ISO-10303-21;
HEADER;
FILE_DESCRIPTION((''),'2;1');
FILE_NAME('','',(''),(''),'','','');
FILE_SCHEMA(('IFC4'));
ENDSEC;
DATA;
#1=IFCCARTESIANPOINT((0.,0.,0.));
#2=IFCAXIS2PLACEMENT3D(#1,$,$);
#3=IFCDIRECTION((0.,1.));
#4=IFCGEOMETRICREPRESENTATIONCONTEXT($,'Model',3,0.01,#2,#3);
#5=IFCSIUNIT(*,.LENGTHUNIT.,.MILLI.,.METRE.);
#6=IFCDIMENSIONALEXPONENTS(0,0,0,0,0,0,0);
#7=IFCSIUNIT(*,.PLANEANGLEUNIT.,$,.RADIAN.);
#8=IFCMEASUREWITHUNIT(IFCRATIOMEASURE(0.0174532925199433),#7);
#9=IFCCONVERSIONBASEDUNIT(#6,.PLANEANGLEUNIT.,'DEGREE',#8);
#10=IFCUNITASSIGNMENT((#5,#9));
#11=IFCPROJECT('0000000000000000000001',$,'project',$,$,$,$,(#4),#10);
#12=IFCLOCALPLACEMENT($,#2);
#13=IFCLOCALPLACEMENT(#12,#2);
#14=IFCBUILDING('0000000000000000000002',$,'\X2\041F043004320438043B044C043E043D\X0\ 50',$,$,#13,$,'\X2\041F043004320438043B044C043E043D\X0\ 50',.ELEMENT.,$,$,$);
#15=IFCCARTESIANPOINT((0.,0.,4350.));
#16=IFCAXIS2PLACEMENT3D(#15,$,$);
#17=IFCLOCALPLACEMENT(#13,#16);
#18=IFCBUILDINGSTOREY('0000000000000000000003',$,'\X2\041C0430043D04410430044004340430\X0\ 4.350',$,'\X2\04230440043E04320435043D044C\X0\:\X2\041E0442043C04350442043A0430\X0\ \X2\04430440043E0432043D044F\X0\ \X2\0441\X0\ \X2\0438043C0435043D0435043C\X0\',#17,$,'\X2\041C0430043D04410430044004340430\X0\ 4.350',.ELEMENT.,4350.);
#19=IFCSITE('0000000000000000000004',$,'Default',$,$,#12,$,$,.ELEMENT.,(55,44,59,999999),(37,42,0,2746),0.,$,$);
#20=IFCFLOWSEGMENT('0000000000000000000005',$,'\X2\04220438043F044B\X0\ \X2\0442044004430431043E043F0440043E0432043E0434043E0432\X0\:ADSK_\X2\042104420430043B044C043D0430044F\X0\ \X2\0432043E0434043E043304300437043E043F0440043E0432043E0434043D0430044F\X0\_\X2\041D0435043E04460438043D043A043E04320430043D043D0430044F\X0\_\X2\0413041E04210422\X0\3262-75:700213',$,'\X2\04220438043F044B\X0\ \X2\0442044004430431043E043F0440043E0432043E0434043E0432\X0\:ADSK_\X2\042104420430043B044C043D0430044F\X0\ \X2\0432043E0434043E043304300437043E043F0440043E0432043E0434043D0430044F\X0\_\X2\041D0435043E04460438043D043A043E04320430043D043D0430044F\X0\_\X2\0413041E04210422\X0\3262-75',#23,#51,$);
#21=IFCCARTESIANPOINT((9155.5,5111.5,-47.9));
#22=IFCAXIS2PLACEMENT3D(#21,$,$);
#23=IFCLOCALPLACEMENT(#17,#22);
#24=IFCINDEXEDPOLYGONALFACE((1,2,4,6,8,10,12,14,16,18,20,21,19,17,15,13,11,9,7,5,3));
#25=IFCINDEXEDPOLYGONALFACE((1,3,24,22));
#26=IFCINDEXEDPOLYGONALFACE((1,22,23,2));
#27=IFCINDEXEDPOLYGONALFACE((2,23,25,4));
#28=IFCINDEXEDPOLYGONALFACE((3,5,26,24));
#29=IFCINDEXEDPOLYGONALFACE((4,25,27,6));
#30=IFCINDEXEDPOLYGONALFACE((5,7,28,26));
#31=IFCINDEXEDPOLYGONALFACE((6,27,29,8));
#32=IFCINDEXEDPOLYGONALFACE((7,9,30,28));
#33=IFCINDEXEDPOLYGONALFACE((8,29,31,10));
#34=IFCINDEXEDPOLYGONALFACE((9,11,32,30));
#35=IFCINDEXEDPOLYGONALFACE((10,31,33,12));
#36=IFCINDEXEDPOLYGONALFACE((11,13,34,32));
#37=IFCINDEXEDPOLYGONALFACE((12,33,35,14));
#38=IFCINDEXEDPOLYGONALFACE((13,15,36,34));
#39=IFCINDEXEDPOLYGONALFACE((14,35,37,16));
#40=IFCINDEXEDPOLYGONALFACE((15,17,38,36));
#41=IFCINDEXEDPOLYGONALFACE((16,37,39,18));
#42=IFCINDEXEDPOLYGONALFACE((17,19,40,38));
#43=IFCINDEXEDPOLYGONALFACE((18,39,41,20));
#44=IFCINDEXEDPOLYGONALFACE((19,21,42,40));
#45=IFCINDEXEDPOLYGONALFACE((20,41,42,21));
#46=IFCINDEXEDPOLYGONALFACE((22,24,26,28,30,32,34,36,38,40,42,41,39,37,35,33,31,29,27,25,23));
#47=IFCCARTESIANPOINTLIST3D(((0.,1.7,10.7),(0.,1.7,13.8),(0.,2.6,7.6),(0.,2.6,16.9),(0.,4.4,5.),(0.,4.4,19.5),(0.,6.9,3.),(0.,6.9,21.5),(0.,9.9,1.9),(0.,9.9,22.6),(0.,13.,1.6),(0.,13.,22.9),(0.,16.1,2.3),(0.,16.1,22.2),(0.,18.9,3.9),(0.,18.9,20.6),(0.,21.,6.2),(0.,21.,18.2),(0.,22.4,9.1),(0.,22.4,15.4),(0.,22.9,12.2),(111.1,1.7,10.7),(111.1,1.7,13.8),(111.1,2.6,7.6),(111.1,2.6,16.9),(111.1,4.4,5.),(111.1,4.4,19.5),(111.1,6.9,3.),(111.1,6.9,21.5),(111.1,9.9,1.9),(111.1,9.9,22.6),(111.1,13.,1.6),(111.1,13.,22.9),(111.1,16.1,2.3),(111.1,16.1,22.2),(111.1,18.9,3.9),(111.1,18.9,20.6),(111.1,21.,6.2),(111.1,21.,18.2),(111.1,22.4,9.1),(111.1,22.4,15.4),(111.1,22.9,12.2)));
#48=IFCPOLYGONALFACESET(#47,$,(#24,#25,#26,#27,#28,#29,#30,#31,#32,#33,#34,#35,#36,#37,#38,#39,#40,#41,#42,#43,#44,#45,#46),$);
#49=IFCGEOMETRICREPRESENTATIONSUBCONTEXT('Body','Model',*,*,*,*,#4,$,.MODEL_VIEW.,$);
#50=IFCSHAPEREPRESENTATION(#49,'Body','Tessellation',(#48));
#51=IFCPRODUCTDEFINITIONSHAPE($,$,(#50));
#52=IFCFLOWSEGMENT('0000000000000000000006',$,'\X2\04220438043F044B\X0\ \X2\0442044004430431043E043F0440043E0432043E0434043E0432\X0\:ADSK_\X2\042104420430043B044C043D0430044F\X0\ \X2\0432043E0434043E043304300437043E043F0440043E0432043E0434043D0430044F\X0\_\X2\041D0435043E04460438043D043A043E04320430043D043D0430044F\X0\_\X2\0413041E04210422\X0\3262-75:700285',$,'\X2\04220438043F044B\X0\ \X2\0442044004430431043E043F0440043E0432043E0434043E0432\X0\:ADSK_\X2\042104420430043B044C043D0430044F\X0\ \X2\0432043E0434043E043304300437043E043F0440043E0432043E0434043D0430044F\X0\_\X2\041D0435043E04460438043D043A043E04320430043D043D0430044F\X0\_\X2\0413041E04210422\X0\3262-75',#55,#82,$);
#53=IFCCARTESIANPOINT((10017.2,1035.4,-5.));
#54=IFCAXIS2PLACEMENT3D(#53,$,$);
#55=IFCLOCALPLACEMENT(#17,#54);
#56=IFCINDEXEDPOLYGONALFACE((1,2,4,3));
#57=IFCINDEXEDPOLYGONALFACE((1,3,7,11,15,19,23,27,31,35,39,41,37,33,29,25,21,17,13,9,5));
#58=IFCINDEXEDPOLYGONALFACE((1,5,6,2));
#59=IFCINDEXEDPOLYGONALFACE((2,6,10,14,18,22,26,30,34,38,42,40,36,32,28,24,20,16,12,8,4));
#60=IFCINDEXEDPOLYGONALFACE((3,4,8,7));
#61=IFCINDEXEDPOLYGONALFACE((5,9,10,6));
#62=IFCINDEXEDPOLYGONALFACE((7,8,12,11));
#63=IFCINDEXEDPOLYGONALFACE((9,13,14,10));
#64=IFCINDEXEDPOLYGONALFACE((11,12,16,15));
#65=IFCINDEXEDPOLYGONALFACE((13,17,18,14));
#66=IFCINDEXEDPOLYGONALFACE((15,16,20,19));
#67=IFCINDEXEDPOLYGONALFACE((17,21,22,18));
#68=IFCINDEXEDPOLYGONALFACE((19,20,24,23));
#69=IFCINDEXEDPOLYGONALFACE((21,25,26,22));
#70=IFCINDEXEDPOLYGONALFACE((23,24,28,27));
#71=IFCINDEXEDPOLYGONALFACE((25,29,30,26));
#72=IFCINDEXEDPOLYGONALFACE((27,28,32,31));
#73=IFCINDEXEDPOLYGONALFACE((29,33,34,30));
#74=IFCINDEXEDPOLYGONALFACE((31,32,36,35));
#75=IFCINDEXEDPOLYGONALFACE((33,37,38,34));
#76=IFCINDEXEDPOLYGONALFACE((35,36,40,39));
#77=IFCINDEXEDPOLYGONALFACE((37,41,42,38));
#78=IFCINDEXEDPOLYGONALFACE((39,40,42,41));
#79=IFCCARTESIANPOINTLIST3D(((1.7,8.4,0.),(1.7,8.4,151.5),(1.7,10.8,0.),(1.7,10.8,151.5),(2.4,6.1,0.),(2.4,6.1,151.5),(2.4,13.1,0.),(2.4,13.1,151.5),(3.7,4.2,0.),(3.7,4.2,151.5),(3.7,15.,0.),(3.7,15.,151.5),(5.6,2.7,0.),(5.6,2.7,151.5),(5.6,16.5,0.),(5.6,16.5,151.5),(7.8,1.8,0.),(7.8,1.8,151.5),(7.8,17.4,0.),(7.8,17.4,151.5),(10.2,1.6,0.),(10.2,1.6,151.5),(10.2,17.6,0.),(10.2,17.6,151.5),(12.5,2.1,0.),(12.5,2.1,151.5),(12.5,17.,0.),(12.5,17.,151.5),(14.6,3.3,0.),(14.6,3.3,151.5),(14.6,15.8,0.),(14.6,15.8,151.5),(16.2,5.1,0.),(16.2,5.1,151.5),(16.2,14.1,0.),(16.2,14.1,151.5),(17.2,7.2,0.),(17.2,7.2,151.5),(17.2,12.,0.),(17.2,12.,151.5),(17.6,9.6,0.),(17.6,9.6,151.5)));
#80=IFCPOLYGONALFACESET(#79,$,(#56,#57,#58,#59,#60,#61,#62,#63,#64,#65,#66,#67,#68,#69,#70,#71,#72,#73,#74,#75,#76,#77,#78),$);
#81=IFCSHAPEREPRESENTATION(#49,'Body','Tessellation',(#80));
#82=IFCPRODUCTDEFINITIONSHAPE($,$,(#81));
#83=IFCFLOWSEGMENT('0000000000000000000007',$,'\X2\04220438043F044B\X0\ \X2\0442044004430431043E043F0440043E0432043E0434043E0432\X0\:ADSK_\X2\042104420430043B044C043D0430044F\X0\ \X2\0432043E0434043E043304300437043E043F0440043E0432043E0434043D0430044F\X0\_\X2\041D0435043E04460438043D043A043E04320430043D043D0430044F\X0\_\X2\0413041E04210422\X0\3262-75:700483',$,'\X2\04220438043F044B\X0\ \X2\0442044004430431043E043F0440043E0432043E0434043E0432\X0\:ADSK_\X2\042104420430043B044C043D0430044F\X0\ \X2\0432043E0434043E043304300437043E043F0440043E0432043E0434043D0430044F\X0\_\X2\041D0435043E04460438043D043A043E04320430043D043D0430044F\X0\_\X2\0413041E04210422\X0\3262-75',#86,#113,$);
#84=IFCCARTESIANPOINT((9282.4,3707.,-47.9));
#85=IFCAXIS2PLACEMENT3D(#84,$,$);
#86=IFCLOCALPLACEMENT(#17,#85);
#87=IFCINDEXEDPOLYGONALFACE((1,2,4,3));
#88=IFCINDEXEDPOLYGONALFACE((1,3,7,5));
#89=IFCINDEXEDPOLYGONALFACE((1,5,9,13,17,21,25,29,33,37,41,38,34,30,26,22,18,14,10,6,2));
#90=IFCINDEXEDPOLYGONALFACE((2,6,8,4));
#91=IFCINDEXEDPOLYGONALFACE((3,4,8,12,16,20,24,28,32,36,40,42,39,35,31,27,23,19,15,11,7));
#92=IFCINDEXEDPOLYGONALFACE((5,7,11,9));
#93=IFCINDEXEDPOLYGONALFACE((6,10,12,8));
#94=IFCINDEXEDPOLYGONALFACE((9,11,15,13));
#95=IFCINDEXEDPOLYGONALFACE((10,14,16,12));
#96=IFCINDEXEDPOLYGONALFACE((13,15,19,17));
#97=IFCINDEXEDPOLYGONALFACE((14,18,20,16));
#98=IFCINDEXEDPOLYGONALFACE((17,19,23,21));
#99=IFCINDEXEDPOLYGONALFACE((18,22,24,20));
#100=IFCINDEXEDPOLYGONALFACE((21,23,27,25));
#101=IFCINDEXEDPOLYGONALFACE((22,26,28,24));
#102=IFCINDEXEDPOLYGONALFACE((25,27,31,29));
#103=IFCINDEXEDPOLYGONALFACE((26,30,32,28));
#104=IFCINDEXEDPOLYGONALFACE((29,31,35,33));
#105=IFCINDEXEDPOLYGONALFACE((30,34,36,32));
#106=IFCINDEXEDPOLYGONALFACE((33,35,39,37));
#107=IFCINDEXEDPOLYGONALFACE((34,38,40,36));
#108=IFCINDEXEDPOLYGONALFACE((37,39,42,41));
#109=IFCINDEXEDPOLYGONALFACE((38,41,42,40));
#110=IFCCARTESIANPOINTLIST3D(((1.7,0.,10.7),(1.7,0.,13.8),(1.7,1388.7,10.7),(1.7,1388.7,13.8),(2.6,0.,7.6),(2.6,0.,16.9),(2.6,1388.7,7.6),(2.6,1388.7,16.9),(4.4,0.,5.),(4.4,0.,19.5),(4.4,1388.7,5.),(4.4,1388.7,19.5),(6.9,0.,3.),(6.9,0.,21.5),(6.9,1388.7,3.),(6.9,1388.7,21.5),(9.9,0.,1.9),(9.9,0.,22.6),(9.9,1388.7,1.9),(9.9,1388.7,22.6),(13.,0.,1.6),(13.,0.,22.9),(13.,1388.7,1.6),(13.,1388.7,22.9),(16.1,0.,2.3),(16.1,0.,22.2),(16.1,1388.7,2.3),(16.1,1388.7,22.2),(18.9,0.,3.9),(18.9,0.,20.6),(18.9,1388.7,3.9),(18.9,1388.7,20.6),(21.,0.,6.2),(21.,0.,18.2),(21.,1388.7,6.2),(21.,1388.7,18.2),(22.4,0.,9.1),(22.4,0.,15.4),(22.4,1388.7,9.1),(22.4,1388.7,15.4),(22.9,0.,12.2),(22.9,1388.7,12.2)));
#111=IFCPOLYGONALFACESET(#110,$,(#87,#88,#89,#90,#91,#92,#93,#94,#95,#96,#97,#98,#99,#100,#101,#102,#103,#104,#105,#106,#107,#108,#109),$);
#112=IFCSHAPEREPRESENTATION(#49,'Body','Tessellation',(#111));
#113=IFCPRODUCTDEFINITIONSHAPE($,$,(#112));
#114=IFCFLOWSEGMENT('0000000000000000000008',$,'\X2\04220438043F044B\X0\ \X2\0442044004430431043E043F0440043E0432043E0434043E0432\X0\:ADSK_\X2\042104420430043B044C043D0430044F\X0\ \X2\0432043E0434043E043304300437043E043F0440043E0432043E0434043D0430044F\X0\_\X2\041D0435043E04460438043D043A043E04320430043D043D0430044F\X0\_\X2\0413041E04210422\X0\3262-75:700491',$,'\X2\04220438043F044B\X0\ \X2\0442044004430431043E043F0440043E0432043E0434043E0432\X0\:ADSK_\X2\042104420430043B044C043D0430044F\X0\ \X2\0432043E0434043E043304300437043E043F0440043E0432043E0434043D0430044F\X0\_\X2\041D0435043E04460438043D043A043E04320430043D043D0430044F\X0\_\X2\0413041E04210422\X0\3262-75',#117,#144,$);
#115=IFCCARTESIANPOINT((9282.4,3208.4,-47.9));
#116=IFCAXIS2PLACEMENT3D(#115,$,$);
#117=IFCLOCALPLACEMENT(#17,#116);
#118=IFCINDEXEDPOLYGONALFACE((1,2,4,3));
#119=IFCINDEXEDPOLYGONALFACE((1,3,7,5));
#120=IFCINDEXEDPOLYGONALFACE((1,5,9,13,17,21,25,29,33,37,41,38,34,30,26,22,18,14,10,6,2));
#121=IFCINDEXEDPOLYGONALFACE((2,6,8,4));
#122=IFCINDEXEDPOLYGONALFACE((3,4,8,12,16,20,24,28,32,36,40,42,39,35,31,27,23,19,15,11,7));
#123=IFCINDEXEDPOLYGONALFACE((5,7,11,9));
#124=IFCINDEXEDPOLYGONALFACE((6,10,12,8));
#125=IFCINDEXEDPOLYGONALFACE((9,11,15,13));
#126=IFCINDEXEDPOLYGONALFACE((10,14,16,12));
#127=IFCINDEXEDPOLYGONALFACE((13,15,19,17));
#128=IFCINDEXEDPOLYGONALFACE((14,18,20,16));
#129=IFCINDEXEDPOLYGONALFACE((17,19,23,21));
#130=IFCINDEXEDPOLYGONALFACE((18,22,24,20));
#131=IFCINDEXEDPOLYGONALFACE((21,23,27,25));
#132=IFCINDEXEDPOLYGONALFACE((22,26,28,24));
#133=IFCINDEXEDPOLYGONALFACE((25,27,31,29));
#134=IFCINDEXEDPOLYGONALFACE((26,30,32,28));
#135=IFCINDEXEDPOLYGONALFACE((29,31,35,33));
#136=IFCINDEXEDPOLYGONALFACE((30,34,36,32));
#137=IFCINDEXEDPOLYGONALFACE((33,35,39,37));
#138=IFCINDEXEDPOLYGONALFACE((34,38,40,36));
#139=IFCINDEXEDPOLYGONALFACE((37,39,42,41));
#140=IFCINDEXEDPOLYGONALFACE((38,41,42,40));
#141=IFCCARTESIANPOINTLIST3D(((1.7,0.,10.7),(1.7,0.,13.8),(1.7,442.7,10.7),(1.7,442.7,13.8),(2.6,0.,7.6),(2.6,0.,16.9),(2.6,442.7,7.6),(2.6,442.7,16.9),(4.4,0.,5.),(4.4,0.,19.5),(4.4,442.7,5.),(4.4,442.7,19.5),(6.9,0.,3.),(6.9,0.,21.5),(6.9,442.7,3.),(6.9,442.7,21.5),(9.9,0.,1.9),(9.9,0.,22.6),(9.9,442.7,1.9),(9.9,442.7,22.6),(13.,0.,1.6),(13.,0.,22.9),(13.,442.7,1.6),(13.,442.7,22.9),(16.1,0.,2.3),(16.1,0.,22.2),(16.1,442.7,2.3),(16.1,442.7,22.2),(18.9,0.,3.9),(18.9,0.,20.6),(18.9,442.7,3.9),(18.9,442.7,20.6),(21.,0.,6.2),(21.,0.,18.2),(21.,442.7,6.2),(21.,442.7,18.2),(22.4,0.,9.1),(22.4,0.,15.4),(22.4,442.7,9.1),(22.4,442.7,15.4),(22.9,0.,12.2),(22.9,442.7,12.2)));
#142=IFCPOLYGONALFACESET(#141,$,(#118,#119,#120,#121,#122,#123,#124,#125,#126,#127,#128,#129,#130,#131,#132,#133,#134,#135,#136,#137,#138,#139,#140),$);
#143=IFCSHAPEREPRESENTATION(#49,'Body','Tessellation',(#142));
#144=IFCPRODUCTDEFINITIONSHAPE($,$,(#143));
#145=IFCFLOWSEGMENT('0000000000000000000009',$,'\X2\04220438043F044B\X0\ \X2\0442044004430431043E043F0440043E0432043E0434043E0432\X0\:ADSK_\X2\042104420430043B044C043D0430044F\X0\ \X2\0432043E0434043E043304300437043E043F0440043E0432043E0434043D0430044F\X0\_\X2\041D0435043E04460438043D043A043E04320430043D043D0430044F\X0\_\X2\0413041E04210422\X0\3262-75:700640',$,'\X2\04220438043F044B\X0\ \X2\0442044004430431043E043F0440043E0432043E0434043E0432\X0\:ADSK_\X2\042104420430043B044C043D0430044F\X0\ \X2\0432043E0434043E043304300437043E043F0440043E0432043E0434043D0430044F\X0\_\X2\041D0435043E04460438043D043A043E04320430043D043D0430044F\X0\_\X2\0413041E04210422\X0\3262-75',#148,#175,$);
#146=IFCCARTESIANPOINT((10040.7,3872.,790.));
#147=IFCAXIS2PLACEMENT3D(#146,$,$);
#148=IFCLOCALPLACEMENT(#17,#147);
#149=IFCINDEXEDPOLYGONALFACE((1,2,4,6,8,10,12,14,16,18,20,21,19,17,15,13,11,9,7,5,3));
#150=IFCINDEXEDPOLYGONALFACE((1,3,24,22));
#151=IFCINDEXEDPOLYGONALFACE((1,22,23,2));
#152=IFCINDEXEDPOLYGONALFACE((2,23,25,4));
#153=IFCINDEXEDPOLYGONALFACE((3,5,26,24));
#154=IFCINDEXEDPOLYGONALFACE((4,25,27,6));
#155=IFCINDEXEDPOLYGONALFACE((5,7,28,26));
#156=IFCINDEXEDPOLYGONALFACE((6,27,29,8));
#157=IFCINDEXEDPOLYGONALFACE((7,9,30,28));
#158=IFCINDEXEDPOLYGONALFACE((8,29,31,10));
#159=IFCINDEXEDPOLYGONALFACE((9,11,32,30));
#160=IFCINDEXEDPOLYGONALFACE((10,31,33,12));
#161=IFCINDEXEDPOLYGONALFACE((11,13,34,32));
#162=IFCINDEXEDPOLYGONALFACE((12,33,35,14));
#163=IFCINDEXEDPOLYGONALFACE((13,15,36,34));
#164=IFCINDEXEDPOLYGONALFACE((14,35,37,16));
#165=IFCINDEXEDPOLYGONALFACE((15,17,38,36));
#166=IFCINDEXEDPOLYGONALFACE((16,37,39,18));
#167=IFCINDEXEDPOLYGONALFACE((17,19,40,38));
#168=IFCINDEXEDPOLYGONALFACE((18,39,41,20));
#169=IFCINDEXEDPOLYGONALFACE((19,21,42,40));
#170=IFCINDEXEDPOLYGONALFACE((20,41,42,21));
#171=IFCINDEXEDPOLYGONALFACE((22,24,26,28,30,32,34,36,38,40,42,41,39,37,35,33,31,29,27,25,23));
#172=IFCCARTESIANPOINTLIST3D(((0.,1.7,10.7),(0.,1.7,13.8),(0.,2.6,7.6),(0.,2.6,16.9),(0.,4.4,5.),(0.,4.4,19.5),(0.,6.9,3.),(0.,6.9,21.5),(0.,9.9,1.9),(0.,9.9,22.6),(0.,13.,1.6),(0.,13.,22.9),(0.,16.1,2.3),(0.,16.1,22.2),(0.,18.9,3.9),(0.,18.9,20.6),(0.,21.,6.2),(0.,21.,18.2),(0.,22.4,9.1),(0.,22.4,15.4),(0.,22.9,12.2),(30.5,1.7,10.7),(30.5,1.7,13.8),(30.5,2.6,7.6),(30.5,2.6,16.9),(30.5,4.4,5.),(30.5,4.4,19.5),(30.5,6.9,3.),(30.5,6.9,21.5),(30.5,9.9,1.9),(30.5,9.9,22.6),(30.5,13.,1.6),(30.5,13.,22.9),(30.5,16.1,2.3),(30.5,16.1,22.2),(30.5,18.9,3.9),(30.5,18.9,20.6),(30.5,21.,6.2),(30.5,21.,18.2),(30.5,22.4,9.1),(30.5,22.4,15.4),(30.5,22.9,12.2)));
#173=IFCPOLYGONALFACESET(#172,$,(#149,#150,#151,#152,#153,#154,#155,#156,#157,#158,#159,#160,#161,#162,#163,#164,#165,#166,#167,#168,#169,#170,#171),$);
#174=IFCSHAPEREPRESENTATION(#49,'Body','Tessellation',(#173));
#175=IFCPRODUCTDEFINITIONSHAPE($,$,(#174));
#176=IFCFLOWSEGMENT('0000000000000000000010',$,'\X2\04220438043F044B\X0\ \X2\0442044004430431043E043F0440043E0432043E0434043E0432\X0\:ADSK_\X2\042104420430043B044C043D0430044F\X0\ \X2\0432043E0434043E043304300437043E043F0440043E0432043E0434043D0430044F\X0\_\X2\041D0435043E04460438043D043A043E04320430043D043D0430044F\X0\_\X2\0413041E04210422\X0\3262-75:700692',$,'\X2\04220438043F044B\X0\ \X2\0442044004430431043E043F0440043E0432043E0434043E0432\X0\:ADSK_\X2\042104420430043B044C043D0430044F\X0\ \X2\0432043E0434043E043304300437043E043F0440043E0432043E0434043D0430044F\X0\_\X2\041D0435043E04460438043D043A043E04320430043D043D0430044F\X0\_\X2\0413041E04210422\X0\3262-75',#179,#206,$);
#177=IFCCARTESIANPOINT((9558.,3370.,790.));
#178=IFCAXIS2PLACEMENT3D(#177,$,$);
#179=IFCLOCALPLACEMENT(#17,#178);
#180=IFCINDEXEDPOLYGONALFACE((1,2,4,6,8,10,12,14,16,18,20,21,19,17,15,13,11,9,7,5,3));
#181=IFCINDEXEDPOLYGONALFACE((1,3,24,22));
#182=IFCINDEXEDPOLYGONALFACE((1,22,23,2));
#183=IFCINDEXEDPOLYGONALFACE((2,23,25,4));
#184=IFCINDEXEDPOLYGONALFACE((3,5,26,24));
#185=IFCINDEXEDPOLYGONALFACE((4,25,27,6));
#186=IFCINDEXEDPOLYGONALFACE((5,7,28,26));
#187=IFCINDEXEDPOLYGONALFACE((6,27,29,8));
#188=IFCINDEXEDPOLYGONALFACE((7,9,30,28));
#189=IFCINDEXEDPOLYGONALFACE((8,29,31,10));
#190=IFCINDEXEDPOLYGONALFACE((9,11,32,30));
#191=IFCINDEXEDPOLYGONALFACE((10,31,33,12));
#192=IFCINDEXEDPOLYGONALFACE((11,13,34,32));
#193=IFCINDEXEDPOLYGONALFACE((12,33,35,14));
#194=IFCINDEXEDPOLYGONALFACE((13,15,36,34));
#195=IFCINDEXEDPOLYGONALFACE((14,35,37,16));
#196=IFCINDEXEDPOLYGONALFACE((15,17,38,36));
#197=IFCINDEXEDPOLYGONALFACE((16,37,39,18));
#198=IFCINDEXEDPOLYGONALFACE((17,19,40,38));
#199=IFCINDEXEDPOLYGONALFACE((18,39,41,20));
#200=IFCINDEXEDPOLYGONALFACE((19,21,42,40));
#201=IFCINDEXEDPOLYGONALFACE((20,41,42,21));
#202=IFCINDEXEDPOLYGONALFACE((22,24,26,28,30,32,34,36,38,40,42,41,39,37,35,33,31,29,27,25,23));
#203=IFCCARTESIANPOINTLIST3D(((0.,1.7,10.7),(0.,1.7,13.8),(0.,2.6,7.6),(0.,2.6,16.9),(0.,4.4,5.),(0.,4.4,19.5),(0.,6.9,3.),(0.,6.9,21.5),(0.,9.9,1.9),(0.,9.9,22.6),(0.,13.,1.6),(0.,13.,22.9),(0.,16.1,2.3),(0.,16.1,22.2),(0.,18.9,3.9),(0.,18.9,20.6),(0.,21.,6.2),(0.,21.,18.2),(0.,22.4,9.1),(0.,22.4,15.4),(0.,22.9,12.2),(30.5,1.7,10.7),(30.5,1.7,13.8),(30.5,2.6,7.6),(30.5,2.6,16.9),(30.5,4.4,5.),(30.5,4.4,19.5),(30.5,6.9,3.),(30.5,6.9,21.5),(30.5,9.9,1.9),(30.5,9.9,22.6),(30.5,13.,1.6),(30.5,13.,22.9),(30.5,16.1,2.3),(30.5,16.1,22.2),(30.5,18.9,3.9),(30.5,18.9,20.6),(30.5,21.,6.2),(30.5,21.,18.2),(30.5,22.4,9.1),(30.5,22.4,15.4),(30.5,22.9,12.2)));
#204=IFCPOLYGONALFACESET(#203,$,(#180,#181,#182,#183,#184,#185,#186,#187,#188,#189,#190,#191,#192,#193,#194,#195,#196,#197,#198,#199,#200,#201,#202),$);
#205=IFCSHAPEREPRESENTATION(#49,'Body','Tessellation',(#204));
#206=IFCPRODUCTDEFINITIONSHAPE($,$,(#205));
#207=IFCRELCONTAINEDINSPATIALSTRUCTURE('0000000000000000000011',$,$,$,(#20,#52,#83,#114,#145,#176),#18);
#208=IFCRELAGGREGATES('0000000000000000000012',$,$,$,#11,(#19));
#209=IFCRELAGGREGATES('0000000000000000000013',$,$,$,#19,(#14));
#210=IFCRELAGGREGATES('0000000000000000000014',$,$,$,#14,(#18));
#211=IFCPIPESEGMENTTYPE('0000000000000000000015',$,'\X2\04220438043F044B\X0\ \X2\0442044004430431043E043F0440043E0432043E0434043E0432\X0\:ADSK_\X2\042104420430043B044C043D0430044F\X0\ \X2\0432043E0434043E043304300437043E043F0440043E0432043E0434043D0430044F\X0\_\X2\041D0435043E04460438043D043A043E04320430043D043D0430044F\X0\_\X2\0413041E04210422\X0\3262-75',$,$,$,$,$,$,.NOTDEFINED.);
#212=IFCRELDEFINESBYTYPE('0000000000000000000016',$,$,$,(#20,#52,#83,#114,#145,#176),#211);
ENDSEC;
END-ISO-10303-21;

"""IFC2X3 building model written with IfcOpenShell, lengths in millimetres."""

from ifc_helpers import new_model, entity, si_unit, converted_unit, direction, frame, frame_2d, origin, origin_2d_with_axis, place, context, subcontext, project, spatial, circle, extrude, type_object, element, save


model = new_model("IFC2X3")

# Units and contexts
model_context = context("Model", 3, precision=0.01, world=origin(), true_north=direction((0.0, 1.0)))
body_context = subcontext(model_context, "Body", "Model", "MODEL_VIEW")
ifc_project = project(units=[si_unit("LENGTHUNIT", "METRE", prefix="MILLI"), converted_unit("PLANEANGLEUNIT", "DEGREE", entity("IfcRatioMeasure", 0.0174532925199433), si_unit("PLANEANGLEUNIT", "RADIAN"), dimensions=[0, 0, 0, 0, 0, 0, 0])], contexts=[model_context])

# Site, building, storey
site_placement = place(None, origin())
site = spatial("IfcSite", under=ifc_project, at=site_placement, Name="Default", CompositionType="ELEMENT", RefLatitude=(55, 44, 59, 999999), RefLongitude=(37, 42, 0, 2746), RefElevation=0.0)
building_placement = place(site_placement, origin())
building = spatial("IfcBuilding", under=site, at=building_placement, Name="Павильон 50", LongName="Павильон 50", CompositionType="ELEMENT")
storey_placement = place(building_placement, frame((0.0, 0.0, 4350.0)))
storey = spatial("IfcBuildingStorey", under=building, at=storey_placement, Name="Мансарда 4.350", ObjectType="Уровень:Отметка уровня с именем", LongName="Мансарда 4.350", CompositionType="ELEMENT", Elevation=4350.0)

# Flow segments
pipe_segment_type = type_object("IfcPipeSegmentType", Name="Типы трубопроводов:ADSK_Стальная водогазопроводная_Неоцинкованная_ГОСТ3262-75", PredefinedType="NOTDEFINED")
flow_segment_1_placement = place(storey_placement, frame((9155.5, 5111.5, -47.9)))
element("IfcFlowSegment", 1, at=flow_segment_1_placement, inside=storey, type_object=pipe_segment_type, Name="Типы трубопроводов:ADSK_Стальная водогазопроводная_Неоцинкованная_ГОСТ3262-75:700213", ObjectType="Типы трубопроводов:ADSK_Стальная водогазопроводная_Неоцинкованная_ГОСТ3262-75", context=body_context, shape_type="SweptSolid", body=[
    extrude(circle(Radius=10.7, at=origin_2d_with_axis()), frame((0.0, 12.2, 12.2), z_axis=(1.0, 0.0, 0.0), x_axis=(0.0, 1.0, 0.0)), (0.0, 0.0, 1.0), 111.1),
])
flow_segment_2_placement = place(storey_placement, frame((10017.2, 1035.4, -5.0)))
element("IfcFlowSegment", 2, at=flow_segment_2_placement, inside=storey, type_object=pipe_segment_type, Name="Типы трубопроводов:ADSK_Стальная водогазопроводная_Неоцинкованная_ГОСТ3262-75:700285", ObjectType="Типы трубопроводов:ADSK_Стальная водогазопроводная_Неоцинкованная_ГОСТ3262-75", context=body_context, shape_type="SweptSolid", body=[
    extrude(circle(Radius=8.0, at=origin_2d_with_axis()), frame((9.6, 9.6, 0.0)), (0.0, 0.0, 1.0), 151.5),
])
flow_segment_3_placement = place(storey_placement, frame((9282.4, 3707.0, -47.9)))
element("IfcFlowSegment", 3, at=flow_segment_3_placement, inside=storey, type_object=pipe_segment_type, Name="Типы трубопроводов:ADSK_Стальная водогазопроводная_Неоцинкованная_ГОСТ3262-75:700483", ObjectType="Типы трубопроводов:ADSK_Стальная водогазопроводная_Неоцинкованная_ГОСТ3262-75", context=body_context, shape_type="SweptSolid", body=[
    extrude(circle(Radius=10.7, at=origin_2d_with_axis()), frame((12.2, 0.0, 12.2), z_axis=(0.0, 1.0, 0.0), x_axis=(1.0, 0.0, 0.0)), (0.0, 0.0, 1.0), 1388.7),
])
flow_segment_4_placement = place(storey_placement, frame((9282.4, 3208.4, -47.9)))
element("IfcFlowSegment", 4, at=flow_segment_4_placement, inside=storey, type_object=pipe_segment_type, Name="Типы трубопроводов:ADSK_Стальная водогазопроводная_Неоцинкованная_ГОСТ3262-75:700491", ObjectType="Типы трубопроводов:ADSK_Стальная водогазопроводная_Неоцинкованная_ГОСТ3262-75", context=body_context, shape_type="SweptSolid", body=[
    extrude(circle(Radius=10.7, at=origin_2d_with_axis()), frame((12.2, 0.0, 12.2), z_axis=(0.0, 1.0, 0.0), x_axis=(1.0, 0.0, 0.0)), (0.0, 0.0, 1.0), 442.7),
])
flow_segment_5_placement = place(storey_placement, frame((10040.7, 3872.0, 790.0)))
element("IfcFlowSegment", 5, at=flow_segment_5_placement, inside=storey, type_object=pipe_segment_type, Name="Типы трубопроводов:ADSK_Стальная водогазопроводная_Неоцинкованная_ГОСТ3262-75:700640", ObjectType="Типы трубопроводов:ADSK_Стальная водогазопроводная_Неоцинкованная_ГОСТ3262-75", context=body_context, shape_type="SweptSolid", body=[
    extrude(circle(Radius=10.7, at=frame_2d((0.0, 0.0), x_axis=(1.0, 0.0))), frame((0.0, 12.2, 12.2), z_axis=(1.0, 0.0, 0.0), x_axis=(0.0, 1.0, 0.0)), (0.0, 0.0, 1.0), 30.5),
])
flow_segment_6_placement = place(storey_placement, frame((9558.0, 3370.0, 790.0)))
element("IfcFlowSegment", 6, at=flow_segment_6_placement, inside=storey, type_object=pipe_segment_type, Name="Типы трубопроводов:ADSK_Стальная водогазопроводная_Неоцинкованная_ГОСТ3262-75:700692", ObjectType="Типы трубопроводов:ADSK_Стальная водогазопроводная_Неоцинкованная_ГОСТ3262-75", context=body_context, shape_type="SweptSolid", body=[
    extrude(circle(Radius=10.7, at=frame_2d((0.0, 0.0), x_axis=(1.0, 0.0))), frame((0.0, 12.2, 12.2), z_axis=(1.0, 0.0, 0.0), x_axis=(0.0, 1.0, 0.0)), (0.0, 0.0, 1.0), 30.5),
])

save(model, "model.ifc")
